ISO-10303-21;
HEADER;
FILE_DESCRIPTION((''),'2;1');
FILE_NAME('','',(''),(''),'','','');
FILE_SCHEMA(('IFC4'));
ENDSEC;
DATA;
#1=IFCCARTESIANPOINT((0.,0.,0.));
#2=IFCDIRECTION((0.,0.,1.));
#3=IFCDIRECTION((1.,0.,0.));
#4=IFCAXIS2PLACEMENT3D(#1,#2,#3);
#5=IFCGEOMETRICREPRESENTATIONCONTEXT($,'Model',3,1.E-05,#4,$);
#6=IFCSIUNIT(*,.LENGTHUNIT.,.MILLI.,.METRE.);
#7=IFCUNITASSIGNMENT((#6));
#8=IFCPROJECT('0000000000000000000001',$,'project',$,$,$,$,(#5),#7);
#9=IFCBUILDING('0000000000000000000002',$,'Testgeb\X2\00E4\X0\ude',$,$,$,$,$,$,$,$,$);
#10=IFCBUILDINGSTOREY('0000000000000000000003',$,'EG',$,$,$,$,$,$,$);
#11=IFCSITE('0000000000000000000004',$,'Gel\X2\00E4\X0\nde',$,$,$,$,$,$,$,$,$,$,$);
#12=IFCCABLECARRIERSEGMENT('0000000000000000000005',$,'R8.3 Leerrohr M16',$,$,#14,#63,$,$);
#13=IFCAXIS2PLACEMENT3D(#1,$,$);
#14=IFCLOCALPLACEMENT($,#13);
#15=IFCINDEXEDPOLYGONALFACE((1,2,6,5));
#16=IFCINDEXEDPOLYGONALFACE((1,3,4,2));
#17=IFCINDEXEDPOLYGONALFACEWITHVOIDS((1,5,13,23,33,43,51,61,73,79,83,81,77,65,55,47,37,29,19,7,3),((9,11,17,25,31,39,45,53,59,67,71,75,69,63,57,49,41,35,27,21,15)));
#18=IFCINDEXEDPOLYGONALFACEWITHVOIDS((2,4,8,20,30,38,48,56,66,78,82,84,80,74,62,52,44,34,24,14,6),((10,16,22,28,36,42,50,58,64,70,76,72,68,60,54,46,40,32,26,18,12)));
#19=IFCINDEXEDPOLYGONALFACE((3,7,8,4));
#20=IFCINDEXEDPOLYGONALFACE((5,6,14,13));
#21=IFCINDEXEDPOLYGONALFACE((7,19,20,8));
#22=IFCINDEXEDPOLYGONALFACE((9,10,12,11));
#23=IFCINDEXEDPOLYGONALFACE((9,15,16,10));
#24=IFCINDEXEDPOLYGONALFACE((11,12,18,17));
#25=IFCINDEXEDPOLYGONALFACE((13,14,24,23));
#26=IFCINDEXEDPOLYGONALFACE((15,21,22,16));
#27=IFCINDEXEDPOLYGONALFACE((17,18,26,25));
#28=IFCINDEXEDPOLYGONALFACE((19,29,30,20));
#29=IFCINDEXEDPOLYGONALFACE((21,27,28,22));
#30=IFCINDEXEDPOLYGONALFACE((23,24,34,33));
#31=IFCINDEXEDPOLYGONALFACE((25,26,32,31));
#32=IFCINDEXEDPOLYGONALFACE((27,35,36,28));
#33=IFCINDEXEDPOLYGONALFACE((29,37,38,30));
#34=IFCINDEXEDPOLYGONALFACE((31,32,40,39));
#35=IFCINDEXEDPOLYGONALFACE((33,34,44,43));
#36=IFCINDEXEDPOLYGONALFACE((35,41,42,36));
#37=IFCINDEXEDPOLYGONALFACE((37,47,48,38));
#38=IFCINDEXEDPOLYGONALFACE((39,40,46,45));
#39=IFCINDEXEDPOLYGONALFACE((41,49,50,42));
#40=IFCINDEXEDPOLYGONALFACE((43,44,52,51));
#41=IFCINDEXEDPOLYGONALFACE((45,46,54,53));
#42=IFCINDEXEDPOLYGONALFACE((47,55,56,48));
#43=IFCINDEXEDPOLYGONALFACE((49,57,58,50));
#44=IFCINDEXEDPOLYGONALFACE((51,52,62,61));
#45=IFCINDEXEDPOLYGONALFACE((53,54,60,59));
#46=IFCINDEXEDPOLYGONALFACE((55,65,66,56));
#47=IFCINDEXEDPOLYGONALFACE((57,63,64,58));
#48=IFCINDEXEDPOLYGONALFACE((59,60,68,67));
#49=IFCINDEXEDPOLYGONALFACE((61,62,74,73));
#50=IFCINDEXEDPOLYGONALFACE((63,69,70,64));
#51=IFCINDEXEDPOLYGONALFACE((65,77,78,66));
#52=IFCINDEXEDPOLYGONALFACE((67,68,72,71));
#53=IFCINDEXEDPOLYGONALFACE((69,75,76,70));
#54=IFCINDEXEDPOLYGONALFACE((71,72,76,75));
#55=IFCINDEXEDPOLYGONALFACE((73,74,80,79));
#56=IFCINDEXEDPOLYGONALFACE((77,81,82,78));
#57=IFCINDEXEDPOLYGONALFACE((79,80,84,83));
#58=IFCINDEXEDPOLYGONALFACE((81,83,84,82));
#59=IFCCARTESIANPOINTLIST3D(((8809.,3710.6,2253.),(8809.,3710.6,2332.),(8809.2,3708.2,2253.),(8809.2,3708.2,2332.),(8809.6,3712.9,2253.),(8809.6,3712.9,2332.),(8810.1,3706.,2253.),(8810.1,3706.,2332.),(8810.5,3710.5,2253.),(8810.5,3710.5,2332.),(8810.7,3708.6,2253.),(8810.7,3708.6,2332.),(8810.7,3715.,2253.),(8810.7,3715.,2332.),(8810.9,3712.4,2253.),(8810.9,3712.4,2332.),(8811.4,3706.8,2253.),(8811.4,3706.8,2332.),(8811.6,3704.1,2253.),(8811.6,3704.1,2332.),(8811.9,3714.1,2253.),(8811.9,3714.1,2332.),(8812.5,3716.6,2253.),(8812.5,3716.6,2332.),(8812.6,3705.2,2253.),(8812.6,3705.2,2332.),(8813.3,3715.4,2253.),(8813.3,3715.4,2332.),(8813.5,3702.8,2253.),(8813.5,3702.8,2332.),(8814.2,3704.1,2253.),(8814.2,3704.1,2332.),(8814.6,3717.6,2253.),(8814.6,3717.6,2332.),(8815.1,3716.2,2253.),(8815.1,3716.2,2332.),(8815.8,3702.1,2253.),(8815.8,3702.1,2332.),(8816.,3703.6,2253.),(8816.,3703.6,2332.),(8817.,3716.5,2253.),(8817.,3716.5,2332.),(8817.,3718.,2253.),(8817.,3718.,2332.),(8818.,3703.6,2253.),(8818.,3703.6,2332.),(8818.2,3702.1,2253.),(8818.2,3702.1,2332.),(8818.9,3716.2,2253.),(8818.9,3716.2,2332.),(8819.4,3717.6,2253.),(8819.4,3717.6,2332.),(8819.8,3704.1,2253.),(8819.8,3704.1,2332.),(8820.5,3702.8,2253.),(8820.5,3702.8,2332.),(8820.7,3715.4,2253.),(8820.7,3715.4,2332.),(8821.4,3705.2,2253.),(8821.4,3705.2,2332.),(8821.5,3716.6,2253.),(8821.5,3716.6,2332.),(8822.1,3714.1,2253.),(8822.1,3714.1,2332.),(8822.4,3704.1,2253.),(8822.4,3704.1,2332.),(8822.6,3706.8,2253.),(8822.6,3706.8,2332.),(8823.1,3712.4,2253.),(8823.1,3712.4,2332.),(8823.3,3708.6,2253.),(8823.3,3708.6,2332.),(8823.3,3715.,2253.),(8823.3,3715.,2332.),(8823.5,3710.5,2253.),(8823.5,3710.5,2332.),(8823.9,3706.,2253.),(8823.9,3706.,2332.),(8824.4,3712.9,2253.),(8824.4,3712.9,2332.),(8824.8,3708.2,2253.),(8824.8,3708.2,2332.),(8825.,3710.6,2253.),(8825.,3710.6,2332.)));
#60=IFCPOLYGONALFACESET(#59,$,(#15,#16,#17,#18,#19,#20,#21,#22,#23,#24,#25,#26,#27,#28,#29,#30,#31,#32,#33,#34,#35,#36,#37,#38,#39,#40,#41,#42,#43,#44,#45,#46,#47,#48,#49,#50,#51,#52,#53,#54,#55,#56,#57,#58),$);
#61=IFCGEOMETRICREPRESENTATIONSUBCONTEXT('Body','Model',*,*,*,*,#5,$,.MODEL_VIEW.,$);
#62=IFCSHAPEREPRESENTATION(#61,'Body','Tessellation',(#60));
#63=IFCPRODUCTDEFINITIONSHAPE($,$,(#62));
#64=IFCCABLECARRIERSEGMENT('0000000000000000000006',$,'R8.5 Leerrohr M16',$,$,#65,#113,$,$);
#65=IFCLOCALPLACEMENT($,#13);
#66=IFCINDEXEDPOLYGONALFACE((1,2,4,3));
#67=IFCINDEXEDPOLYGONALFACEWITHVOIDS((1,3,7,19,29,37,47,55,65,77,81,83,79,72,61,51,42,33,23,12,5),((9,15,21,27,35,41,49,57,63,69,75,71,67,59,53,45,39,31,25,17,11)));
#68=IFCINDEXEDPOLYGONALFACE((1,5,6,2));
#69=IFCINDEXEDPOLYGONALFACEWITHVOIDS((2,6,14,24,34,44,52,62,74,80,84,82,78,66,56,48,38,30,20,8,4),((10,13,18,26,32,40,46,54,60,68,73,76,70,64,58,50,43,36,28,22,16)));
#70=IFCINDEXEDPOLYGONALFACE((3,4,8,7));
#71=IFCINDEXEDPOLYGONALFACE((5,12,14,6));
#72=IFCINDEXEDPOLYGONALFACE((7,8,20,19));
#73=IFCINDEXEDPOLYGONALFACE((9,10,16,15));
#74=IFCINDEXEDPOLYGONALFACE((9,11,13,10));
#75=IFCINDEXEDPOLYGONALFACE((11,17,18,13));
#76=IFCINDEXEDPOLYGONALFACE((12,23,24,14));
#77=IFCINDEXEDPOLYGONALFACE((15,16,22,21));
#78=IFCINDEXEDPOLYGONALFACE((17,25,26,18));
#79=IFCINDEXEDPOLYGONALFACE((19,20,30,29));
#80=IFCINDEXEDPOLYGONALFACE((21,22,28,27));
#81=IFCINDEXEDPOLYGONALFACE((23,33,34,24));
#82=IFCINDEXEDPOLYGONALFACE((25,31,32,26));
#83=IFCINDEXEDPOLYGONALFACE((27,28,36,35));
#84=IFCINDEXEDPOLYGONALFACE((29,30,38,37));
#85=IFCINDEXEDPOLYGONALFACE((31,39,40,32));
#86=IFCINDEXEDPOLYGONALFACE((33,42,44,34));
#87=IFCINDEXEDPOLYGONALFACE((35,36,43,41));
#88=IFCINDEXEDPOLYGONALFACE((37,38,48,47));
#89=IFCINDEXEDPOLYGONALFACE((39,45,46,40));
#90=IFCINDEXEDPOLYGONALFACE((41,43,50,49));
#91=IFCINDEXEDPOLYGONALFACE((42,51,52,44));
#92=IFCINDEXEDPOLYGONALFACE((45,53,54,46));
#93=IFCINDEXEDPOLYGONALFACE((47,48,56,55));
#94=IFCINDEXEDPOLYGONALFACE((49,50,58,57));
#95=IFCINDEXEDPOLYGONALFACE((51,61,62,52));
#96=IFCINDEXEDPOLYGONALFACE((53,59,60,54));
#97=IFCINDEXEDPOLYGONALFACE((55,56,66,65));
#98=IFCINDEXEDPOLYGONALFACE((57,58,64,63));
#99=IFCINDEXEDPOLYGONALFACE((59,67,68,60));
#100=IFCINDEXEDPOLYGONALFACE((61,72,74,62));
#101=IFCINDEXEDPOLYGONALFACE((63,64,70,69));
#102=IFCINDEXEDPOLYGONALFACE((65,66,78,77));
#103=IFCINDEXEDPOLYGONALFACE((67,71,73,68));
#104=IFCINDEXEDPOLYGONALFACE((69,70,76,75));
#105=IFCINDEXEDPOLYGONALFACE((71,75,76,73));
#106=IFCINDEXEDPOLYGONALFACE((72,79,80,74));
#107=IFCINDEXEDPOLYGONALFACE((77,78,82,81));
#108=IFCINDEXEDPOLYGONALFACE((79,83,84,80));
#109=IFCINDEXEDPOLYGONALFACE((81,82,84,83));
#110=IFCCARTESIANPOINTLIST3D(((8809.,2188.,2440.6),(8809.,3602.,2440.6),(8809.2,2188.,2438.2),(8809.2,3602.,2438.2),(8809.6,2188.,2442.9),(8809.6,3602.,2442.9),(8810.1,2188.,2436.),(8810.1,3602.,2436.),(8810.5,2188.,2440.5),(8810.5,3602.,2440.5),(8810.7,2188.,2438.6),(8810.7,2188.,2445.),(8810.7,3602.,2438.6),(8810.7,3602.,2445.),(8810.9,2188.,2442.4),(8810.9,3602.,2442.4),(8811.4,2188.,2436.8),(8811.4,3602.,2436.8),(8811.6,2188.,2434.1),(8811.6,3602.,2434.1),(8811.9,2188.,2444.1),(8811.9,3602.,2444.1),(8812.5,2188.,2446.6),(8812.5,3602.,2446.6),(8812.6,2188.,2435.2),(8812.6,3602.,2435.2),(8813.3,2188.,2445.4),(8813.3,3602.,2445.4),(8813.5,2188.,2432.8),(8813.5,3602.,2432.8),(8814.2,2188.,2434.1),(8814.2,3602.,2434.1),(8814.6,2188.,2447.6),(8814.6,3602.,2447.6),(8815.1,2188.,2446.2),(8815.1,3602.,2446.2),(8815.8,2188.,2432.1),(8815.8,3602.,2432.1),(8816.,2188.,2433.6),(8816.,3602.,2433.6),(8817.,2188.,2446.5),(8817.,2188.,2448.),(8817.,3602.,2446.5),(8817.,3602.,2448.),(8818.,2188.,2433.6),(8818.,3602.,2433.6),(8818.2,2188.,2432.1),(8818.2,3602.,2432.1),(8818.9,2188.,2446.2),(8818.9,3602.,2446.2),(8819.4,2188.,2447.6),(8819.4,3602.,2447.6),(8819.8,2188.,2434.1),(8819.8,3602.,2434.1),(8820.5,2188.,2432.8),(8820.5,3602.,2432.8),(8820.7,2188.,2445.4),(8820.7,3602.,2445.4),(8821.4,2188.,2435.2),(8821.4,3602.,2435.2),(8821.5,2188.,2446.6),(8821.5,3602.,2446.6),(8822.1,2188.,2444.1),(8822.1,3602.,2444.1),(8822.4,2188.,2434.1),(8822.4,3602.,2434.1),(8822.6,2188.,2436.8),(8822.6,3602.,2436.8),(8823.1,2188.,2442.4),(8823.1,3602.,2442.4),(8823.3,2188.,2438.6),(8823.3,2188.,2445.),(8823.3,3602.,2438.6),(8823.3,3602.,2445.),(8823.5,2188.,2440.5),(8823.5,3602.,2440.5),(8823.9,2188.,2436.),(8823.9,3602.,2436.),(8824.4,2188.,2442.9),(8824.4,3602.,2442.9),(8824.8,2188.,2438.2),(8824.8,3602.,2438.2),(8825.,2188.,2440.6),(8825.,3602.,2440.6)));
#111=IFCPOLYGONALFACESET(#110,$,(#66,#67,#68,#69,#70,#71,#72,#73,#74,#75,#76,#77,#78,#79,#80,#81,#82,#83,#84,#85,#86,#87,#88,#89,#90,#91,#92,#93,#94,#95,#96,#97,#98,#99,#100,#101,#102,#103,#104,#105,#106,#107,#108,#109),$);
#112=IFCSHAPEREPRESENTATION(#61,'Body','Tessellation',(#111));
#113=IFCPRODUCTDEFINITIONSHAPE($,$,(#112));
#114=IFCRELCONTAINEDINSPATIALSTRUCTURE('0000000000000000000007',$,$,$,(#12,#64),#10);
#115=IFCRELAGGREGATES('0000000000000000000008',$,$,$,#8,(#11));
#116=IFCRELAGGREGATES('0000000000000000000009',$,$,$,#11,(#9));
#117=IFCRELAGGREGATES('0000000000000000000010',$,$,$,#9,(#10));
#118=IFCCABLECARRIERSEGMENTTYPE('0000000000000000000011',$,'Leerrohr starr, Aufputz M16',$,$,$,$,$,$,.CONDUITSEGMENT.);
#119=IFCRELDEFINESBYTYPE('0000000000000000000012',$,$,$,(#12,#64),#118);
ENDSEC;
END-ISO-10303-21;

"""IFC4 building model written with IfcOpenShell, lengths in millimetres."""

from ifc_helpers import new_model, si_unit, frame, origin_with_axes, place, context, subcontext, project, spatial, hollow_circle, extrude, type_object, element, save


model = new_model("IFC4")

# Units and contexts
model_context = context("Model", 3, precision=1e-05, world=origin_with_axes())
body_context = subcontext(model_context, "Body", "Model", "MODEL_VIEW")
ifc_project = project(units=[si_unit("LENGTHUNIT", "METRE", prefix="MILLI")], contexts=[model_context])

# Site, building, storey
site = spatial("IfcSite", under=ifc_project, Name="Gelände")
building = spatial("IfcBuilding", under=site, Name="Testgebäude")
storey = spatial("IfcBuildingStorey", under=building, Name="EG")

# Cable carrier segments
cable_carrier_segment_type_1 = type_object("IfcCableCarrierSegmentType", Name="Leerrohr starr, Aufputz M16", PredefinedType="CONDUITSEGMENT")
cable_carrier_segment_1_placement = place(None, frame((8817.0, 3710.0, 2253.0), z_axis=(0.0, 0.0, 1.0), x_axis=(0.0, 1.0, 0.0)))
element("IfcCableCarrierSegment", 1, at=cable_carrier_segment_1_placement, inside=storey, type_object=cable_carrier_segment_type_1, Name="R8.3 Leerrohr M16", context=body_context, shape_type="SweptSolid", body=[
    extrude(hollow_circle(Radius=8.0, WallThickness=1.5), None, (0.0, 0.0, 1.0), 79.0),
])
cable_carrier_segment_2_placement = place(None, frame((8817.0, 3602.0, 2440.0), z_axis=(0.0, -1.0, 0.0), x_axis=(0.0, 0.0, 1.0)))
element("IfcCableCarrierSegment", 2, at=cable_carrier_segment_2_placement, inside=storey, type_object=cable_carrier_segment_type_1, Name="R8.5 Leerrohr M16", context=body_context, shape_type="SweptSolid", body=[
    extrude(hollow_circle(Radius=8.0, WallThickness=1.5), None, (0.0, 0.0, 1.0), 1414.0),
])

save(model, "model.ifc")
